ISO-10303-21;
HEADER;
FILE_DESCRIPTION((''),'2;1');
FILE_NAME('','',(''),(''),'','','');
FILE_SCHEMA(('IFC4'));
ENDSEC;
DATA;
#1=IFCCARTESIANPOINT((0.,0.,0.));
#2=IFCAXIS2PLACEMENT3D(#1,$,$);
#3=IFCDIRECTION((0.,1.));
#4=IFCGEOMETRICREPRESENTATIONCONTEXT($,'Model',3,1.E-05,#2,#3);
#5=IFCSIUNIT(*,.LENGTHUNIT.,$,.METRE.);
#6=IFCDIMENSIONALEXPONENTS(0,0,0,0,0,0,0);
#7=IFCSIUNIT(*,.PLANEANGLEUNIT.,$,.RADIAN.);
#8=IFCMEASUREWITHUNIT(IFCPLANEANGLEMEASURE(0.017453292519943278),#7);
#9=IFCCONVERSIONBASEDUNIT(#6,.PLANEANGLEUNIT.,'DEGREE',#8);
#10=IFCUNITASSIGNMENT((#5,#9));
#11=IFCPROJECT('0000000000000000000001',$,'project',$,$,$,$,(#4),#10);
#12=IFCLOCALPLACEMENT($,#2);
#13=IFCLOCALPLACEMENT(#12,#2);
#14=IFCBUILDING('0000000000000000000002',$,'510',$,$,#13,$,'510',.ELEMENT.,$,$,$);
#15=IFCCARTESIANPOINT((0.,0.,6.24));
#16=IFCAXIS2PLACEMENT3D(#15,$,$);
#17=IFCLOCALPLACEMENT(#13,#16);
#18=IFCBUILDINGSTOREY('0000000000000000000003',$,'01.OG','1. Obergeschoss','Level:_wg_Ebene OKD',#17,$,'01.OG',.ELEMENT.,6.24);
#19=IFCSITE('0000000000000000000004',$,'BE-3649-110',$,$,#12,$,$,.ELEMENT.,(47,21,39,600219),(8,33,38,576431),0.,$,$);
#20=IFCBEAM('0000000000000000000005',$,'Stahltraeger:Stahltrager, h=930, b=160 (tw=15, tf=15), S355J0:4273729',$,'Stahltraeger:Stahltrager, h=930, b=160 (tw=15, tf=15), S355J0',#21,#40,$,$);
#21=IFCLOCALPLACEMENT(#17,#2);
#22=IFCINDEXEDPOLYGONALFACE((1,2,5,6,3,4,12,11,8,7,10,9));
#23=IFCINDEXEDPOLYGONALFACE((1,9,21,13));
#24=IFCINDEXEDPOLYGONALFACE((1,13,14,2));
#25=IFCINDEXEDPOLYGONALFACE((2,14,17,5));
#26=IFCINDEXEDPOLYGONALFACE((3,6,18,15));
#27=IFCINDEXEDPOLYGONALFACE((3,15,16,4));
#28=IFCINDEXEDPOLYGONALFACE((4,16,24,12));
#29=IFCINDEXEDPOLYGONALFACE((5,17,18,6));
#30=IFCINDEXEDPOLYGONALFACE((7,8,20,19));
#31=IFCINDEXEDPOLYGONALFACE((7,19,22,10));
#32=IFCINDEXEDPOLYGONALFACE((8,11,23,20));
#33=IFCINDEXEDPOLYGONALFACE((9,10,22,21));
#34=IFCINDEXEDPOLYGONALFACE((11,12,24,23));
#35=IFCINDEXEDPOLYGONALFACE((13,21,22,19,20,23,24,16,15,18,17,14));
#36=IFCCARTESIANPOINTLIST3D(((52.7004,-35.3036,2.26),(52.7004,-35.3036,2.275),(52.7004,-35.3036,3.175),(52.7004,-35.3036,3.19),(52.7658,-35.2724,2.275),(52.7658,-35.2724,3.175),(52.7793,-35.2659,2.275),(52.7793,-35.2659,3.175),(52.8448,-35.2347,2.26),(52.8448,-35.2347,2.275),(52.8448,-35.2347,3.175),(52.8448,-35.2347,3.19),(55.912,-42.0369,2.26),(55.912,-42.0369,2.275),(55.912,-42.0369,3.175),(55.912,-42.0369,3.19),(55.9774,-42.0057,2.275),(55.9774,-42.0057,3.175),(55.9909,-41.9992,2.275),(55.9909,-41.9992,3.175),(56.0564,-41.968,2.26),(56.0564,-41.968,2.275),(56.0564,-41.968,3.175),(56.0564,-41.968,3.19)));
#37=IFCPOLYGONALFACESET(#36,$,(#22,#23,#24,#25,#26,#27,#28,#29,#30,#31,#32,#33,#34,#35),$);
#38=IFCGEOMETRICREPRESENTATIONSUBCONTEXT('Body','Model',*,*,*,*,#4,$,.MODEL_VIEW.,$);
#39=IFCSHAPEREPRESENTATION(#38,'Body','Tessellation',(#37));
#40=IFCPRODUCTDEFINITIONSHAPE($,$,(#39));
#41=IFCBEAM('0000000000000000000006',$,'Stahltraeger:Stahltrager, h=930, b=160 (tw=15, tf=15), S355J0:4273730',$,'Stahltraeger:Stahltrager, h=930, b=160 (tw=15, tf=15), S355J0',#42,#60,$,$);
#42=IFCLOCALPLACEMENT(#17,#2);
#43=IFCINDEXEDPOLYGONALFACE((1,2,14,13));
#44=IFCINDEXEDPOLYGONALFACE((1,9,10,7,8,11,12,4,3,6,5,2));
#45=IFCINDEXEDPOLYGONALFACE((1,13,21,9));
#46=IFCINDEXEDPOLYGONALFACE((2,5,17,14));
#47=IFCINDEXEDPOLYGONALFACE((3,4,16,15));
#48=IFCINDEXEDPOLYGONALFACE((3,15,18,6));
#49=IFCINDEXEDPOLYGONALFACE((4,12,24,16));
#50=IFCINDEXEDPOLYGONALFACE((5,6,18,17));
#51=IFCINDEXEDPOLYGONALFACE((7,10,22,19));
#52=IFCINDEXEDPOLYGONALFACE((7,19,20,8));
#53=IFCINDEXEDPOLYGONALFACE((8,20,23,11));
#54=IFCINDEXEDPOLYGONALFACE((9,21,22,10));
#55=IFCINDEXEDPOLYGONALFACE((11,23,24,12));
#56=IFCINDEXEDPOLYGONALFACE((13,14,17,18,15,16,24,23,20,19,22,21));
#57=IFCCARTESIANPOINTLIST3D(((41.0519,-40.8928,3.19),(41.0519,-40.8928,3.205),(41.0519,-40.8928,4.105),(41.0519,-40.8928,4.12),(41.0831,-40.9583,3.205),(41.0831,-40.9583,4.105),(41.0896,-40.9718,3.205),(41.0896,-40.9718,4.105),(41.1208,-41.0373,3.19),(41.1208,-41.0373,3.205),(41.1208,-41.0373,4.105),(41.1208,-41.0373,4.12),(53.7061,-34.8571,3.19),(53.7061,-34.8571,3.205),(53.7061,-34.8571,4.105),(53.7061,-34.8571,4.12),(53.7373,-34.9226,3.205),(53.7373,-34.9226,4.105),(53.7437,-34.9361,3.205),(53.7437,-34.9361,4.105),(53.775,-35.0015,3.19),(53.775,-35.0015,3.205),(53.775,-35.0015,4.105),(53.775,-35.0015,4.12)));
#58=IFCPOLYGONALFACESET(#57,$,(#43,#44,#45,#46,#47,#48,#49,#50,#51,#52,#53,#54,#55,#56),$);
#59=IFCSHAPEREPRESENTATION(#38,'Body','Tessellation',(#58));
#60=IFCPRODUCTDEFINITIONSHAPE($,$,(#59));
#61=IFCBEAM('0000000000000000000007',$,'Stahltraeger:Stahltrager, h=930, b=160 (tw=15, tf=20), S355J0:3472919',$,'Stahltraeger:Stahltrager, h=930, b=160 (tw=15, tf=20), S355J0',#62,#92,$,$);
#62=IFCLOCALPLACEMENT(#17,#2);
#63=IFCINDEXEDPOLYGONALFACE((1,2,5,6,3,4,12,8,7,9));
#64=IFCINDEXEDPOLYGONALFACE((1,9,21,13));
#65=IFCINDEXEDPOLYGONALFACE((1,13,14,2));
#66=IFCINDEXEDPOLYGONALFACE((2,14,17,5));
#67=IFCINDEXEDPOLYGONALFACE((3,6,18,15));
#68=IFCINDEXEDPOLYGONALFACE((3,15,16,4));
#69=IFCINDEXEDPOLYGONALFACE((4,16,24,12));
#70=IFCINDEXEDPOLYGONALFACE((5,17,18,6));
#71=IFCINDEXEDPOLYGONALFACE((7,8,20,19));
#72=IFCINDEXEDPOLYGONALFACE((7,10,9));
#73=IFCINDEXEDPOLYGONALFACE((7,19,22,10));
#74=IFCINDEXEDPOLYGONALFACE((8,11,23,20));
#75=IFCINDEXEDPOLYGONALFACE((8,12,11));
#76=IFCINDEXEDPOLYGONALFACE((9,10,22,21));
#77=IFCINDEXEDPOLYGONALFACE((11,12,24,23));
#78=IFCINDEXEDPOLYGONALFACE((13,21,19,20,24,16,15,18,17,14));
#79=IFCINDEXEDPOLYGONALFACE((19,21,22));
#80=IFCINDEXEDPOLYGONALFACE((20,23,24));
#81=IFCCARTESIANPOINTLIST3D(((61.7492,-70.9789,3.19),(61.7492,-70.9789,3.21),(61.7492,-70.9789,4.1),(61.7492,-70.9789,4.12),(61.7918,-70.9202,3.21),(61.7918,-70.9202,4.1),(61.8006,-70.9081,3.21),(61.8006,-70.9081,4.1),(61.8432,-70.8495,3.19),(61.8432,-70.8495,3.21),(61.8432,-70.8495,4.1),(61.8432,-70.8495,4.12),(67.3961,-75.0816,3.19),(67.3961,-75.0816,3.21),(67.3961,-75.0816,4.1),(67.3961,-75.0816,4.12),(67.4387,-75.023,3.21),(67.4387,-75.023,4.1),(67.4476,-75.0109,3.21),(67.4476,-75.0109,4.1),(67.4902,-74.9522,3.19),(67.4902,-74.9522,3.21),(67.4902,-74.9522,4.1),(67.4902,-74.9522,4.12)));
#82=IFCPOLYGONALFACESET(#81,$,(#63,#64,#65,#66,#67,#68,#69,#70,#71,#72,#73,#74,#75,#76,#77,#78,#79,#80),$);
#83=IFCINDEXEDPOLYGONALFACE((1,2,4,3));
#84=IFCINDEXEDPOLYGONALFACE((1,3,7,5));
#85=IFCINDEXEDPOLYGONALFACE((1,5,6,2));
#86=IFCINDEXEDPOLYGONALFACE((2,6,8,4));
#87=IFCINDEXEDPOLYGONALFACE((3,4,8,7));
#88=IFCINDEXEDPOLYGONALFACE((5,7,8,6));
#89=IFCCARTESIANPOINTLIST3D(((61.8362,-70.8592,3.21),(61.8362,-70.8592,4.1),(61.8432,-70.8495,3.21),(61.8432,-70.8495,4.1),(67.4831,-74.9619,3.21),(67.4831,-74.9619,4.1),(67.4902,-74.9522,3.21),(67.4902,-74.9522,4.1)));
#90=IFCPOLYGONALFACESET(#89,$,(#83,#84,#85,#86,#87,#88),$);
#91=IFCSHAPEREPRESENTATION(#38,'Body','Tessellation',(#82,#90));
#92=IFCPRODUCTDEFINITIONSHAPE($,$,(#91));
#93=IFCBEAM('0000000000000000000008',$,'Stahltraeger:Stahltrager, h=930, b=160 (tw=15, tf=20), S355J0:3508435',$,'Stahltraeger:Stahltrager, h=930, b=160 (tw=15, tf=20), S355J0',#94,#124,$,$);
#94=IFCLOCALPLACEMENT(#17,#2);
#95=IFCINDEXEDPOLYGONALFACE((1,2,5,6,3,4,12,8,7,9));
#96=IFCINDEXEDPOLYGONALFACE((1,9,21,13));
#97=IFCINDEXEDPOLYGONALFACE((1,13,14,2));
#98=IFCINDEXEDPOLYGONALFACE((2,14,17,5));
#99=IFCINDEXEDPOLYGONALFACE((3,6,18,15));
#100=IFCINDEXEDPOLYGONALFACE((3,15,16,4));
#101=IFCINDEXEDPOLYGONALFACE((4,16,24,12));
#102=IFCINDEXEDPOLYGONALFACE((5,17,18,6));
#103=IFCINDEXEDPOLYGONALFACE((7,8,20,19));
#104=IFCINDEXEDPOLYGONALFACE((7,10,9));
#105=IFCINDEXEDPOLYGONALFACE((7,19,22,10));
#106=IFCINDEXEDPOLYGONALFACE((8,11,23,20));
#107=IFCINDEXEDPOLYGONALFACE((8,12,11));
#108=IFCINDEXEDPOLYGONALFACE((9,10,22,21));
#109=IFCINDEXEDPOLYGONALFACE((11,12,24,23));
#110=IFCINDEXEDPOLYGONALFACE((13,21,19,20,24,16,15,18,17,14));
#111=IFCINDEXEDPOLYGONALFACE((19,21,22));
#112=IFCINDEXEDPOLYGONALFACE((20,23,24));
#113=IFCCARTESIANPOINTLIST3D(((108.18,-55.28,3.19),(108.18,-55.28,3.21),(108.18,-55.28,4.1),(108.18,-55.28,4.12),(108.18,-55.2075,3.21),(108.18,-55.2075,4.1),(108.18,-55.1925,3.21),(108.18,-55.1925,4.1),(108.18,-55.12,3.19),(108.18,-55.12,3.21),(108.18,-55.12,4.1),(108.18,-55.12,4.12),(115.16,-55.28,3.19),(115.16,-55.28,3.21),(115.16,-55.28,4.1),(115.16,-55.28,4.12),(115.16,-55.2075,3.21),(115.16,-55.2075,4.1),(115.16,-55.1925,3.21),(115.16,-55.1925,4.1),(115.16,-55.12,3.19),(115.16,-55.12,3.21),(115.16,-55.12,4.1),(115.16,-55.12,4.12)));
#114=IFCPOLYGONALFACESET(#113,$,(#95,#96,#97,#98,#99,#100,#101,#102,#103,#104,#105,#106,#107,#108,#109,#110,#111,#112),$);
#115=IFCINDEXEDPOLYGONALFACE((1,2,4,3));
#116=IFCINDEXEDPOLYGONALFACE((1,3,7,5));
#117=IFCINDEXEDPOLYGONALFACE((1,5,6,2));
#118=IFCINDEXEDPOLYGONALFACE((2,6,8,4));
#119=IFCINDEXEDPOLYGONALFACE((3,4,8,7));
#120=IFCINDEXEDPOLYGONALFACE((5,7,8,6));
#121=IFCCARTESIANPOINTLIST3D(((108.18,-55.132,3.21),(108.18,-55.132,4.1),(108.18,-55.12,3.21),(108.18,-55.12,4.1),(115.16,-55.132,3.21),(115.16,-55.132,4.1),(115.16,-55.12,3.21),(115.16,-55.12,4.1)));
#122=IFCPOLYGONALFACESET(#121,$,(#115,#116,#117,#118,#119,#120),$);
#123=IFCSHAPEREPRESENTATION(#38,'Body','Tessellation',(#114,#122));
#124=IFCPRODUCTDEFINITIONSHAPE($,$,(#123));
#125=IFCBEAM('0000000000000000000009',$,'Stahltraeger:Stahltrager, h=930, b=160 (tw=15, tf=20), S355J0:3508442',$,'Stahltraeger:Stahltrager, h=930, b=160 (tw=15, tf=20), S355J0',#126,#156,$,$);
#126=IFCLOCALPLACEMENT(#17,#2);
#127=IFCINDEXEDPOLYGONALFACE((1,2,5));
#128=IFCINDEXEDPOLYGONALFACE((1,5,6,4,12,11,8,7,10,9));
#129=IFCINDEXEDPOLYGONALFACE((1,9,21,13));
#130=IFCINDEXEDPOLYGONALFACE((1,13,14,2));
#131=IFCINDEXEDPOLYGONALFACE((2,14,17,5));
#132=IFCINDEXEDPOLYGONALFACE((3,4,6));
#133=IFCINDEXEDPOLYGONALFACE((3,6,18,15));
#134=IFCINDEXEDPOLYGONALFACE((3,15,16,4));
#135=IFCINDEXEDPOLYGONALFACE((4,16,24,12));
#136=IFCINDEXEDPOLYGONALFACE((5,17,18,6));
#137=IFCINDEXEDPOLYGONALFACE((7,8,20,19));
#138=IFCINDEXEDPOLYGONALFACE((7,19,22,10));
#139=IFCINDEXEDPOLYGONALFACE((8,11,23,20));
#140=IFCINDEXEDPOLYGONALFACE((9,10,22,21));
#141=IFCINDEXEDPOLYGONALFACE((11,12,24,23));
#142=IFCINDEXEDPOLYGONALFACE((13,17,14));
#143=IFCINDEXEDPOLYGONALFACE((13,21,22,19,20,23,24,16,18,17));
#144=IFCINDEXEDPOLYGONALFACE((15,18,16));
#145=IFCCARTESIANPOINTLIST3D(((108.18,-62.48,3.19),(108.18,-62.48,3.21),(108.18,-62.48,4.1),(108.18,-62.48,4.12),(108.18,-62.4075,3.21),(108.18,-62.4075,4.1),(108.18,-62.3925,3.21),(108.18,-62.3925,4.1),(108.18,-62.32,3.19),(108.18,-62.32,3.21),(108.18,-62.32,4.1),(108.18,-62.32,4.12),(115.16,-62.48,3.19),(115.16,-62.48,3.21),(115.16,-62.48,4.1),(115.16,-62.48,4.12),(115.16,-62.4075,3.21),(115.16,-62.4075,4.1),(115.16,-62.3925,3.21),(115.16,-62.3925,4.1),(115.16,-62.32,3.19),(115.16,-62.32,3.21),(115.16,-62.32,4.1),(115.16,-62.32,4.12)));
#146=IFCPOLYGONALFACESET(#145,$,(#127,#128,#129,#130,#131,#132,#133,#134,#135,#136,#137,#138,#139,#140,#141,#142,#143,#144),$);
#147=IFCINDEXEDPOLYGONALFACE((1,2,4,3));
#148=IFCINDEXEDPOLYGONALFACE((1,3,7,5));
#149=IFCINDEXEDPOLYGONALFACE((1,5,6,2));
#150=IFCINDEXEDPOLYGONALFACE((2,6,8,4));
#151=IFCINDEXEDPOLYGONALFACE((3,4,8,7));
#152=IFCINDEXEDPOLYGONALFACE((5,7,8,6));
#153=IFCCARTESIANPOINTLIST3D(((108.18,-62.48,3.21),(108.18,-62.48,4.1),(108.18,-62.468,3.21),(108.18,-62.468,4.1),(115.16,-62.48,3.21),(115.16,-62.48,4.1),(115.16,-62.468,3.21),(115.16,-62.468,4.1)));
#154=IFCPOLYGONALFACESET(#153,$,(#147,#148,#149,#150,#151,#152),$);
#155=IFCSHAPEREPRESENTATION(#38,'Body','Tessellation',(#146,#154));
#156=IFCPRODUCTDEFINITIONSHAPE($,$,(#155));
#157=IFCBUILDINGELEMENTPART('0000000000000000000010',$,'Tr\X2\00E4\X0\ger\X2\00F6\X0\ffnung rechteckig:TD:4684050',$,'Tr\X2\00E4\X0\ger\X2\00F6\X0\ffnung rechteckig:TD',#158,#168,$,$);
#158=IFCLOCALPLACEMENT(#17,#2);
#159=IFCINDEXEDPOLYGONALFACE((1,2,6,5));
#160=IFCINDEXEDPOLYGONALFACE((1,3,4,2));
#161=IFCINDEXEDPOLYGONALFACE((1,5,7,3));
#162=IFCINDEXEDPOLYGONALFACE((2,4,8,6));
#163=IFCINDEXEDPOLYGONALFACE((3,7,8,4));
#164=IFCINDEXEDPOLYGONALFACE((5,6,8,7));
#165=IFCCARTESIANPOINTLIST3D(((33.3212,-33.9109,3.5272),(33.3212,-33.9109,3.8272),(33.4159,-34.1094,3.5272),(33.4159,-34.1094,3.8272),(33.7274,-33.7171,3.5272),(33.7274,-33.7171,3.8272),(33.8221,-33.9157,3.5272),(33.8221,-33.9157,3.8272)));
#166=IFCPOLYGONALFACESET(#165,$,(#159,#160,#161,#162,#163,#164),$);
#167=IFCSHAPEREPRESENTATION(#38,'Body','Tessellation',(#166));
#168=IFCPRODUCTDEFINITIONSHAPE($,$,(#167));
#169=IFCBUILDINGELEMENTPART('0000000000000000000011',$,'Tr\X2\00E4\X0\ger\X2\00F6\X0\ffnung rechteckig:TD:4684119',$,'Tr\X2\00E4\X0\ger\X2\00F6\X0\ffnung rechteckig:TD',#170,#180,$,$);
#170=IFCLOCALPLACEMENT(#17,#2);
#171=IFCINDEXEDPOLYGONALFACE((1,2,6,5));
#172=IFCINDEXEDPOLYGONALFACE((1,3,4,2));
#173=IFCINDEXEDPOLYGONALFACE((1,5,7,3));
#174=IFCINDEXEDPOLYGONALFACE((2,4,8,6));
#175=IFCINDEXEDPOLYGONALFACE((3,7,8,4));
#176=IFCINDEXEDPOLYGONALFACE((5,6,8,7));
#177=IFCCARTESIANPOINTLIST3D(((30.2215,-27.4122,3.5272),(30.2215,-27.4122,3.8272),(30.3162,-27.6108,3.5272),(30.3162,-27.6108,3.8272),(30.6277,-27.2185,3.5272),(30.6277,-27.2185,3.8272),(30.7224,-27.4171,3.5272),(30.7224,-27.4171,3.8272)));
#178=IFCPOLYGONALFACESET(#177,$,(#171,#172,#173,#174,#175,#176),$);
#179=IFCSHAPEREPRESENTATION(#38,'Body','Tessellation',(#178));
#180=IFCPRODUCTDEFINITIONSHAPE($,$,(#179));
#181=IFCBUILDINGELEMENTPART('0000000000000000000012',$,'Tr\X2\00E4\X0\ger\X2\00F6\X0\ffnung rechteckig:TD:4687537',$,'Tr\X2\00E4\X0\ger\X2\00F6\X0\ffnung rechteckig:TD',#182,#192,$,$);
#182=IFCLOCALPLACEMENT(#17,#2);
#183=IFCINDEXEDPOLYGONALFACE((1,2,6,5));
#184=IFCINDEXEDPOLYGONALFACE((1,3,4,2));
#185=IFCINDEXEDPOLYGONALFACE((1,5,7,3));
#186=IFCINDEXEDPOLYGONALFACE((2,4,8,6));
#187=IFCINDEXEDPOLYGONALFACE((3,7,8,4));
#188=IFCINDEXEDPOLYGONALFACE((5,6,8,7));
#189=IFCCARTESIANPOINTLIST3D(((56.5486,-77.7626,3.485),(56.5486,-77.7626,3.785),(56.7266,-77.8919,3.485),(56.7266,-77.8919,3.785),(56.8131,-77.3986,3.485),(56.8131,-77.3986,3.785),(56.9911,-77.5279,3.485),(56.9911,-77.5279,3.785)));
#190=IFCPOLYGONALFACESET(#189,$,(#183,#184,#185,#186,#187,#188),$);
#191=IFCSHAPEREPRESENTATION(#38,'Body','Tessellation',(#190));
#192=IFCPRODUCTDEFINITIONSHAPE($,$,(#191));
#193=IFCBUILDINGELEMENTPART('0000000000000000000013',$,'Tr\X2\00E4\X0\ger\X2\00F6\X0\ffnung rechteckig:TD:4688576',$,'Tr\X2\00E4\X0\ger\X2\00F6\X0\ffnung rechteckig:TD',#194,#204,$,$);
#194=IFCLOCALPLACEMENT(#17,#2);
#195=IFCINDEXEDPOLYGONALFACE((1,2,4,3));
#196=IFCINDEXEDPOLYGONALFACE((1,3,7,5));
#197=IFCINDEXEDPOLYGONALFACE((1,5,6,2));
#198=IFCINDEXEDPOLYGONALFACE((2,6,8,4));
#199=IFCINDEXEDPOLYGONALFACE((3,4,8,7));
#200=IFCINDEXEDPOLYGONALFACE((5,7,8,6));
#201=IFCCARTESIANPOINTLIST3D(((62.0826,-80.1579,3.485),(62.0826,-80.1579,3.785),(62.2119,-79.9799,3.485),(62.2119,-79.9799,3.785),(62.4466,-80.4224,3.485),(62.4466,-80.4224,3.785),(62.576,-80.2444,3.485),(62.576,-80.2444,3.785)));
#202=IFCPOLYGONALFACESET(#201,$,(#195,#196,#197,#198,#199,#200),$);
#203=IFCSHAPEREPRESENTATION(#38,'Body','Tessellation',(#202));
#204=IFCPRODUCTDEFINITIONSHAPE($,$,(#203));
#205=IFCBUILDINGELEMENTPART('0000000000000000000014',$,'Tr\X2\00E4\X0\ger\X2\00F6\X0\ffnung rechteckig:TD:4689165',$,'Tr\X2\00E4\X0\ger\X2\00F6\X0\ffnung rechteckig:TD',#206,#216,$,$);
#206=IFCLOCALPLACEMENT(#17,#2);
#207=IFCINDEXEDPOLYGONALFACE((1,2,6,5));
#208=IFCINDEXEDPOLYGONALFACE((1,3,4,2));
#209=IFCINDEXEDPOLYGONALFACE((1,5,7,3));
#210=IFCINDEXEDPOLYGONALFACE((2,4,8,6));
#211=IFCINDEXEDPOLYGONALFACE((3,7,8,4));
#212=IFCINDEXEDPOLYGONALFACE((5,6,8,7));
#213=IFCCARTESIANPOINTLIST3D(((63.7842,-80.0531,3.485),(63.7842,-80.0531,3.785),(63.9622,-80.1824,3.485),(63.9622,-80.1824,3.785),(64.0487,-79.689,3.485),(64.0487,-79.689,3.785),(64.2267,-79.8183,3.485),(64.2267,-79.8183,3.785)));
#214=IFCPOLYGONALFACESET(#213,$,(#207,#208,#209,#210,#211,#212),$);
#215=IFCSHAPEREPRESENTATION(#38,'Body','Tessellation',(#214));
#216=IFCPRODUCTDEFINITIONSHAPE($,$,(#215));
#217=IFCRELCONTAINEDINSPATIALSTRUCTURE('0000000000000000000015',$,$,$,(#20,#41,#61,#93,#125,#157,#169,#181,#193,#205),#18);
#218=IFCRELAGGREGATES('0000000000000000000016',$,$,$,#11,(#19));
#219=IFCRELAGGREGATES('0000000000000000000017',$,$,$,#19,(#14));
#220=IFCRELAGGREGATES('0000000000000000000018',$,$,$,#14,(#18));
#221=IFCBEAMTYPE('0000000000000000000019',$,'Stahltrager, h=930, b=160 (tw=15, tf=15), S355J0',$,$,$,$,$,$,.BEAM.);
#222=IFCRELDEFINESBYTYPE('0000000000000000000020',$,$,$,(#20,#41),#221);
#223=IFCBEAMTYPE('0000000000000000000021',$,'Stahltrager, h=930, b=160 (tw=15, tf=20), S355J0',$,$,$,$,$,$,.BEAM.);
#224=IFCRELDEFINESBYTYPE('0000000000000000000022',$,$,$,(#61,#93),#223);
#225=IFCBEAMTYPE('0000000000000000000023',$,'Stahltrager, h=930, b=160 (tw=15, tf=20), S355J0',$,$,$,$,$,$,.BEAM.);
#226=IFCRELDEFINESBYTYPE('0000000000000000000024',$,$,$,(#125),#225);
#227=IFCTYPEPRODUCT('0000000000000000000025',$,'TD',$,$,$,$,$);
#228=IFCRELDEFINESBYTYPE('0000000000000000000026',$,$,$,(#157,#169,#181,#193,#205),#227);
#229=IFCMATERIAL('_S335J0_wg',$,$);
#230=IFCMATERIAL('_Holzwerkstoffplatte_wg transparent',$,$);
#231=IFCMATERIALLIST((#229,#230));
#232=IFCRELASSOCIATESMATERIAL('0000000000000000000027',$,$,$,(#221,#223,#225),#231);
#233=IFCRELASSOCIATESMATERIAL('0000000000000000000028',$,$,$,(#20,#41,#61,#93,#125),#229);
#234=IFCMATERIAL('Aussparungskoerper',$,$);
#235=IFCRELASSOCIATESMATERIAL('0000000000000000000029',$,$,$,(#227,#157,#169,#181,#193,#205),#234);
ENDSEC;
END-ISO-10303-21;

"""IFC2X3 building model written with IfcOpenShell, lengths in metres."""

from ifc_helpers import new_model, entity, si_unit, converted_unit, direction, frame, frame_2d, origin, origin_2d_with_axis, place, context, subcontext, project, spatial, rectangle, i_section, extrude, source, transform, mapped, material, material_list, type_object, type_shapes, element, save


model = new_model("IFC2X3")

# Units and contexts
model_context = context("Model", 3, precision=1e-05, world=origin(), true_north=direction((0.0, 1.0)))
body_context = subcontext(model_context, "Body", "Model", "MODEL_VIEW")
ifc_project = project(units=[si_unit("LENGTHUNIT", "METRE"), converted_unit("PLANEANGLEUNIT", "DEGREE", entity("IfcPlaneAngleMeasure", 0.017453292519943278), si_unit("PLANEANGLEUNIT", "RADIAN"), dimensions=[0, 0, 0, 0, 0, 0, 0])], contexts=[model_context])

# Site, building, storey
site_placement = place(None, origin())
site = spatial("IfcSite", under=ifc_project, at=site_placement, Name="BE-3649-110", CompositionType="ELEMENT", RefLatitude=(47, 21, 39, 600219), RefLongitude=(8, 33, 38, 576431), RefElevation=0.0)
building_placement = place(site_placement, origin())
building = spatial("IfcBuilding", under=site, at=building_placement, Name="510", LongName="510", CompositionType="ELEMENT")
storey_placement = place(building_placement, frame((0.0, 0.0, 6.24)))
storey = spatial("IfcBuildingStorey", under=building, at=storey_placement, Name="01.OG", Description="1. Obergeschoss", ObjectType="Level:_wg_Ebene OKD", LongName="01.OG", CompositionType="ELEMENT", Elevation=6.24)

# Beams
ifc_material_1 = material(Name="_S335J0_wg")
ifc_material_2 = material(Name="_Holzwerkstoffplatte_wg transparent")
ifc_material_list = material_list([ifc_material_1, ifc_material_2])
beam_type_1 = type_object("IfcBeamType", Name="Stahltrager, h=930, b=160 (tw=15, tf=15), S355J0", PredefinedType="BEAM", material=ifc_material_list)
beam_1_placement = place(storey_placement, frame((52.7726, -35.2691, 3.19), z_axis=(0.0, 0.0, 1.0), x_axis=(0.430511, -0.902585, 0.0)))
element("IfcBeam", 1, at=beam_1_placement, inside=storey, type_object=beam_type_1, material=ifc_material_1, Name="Stahltraeger:Stahltrager, h=930, b=160 (tw=15, tf=15), S355J0:4273729", ObjectType="Stahltraeger:Stahltrager, h=930, b=160 (tw=15, tf=15), S355J0", context=body_context, shape_type="SweptSolid", body=[
    extrude(i_section(OverallWidth=0.16, OverallDepth=0.93, WebThickness=0.015, FlangeThickness=0.015, at=frame_2d((0.0, 0.0), x_axis=(0.0, 1.0))), frame((0.0, 0.0, -0.465), z_axis=(1.0, 0.0, 0.0), x_axis=(0.0, 0.0, -1.0)), (0.0, 0.0, 1.0), 7.46),
])
beam_2_placement = place(storey_placement, frame((41.0863, -40.9651, 4.12), z_axis=(0.0, 0.0, 1.0), x_axis=(0.902585, 0.430511, 0.0)))
element("IfcBeam", 2, at=beam_2_placement, inside=storey, type_object=beam_type_1, material=ifc_material_1, Name="Stahltraeger:Stahltrager, h=930, b=160 (tw=15, tf=15), S355J0:4273730", ObjectType="Stahltraeger:Stahltrager, h=930, b=160 (tw=15, tf=15), S355J0", context=body_context, shape_type="SweptSolid", body=[
    extrude(i_section(OverallWidth=0.16, OverallDepth=0.93, WebThickness=0.015, FlangeThickness=0.015, at=frame_2d((0.0, 0.0), x_axis=(0.0, 1.0))), frame((0.0, 0.0, -0.465), z_axis=(1.0, 0.0, 0.0), x_axis=(0.0, 0.0, -1.0)), (0.0, 0.0, 1.0), 14.0199),
])
beam_type_2 = type_object("IfcBeamType", Name="Stahltrager, h=930, b=160 (tw=15, tf=20), S355J0", PredefinedType="BEAM", material=ifc_material_list)
shared_shape_1 = source(origin(), body_context, "Body", "SweptSolid", [
    extrude(i_section(OverallWidth=0.16, OverallDepth=0.93, WebThickness=0.015, FlangeThickness=0.02, at=frame_2d((0.0, 0.0), x_axis=(0.0, 1.0))), frame((-3.49, 0.0, 0.0), z_axis=(1.0, 0.0, 0.0), x_axis=(0.0, 0.0, -1.0)), (0.0, 0.0, 1.0), 6.98),
    extrude(rectangle(XDim=0.89, YDim=0.012, at=origin_2d_with_axis()), frame((-3.49, 0.074, 0.0), z_axis=(1.0, 0.0, 0.0), x_axis=(0.0, 0.0, -1.0)), (0.0, 0.0, 1.0), 6.98),
])
type_shapes(beam_type_2, [shared_shape_1])
beam_3_placement = place(storey_placement, frame((64.6197, -72.9655, 3.655), z_axis=(0.0, 0.0, 1.0), x_axis=(0.809017, -0.587785, 0.0)))
element("IfcBeam", 3, at=beam_3_placement, inside=storey, type_object=beam_type_2, material=ifc_material_1, Name="Stahltraeger:Stahltrager, h=930, b=160 (tw=15, tf=20), S355J0:3472919", ObjectType="Stahltraeger:Stahltrager, h=930, b=160 (tw=15, tf=20), S355J0", context=body_context, shape_type="MappedRepresentation", body=[
    mapped(shared_shape_1, transform((0.0, 0.0, 0.0), scale=1.0)),
])
beam_4_placement = place(storey_placement, frame((111.67, -55.2, 3.655)))
element("IfcBeam", 4, at=beam_4_placement, inside=storey, type_object=beam_type_2, material=ifc_material_1, Name="Stahltraeger:Stahltrager, h=930, b=160 (tw=15, tf=20), S355J0:3508435", ObjectType="Stahltraeger:Stahltrager, h=930, b=160 (tw=15, tf=20), S355J0", context=body_context, shape_type="MappedRepresentation", body=[
    mapped(shared_shape_1, transform((0.0, 0.0, 0.0), scale=1.0)),
])
beam_type_3 = type_object("IfcBeamType", Name="Stahltrager, h=930, b=160 (tw=15, tf=20), S355J0", PredefinedType="BEAM", material=ifc_material_list)
shared_shape_2 = source(origin(), body_context, "Body", "SweptSolid", [
    extrude(i_section(OverallWidth=0.16, OverallDepth=0.93, WebThickness=0.015, FlangeThickness=0.02, at=frame_2d((0.0, 0.0), x_axis=(0.0, 1.0))), frame((-3.49, 0.0, 0.0), z_axis=(1.0, 0.0, 0.0), x_axis=(0.0, 0.0, -1.0)), (0.0, 0.0, 1.0), 6.98),
    extrude(rectangle(XDim=0.89, YDim=0.012, at=frame_2d((0.0, 0.0), x_axis=(1.0, 0.0))), frame((-3.49, -0.074, 0.0), z_axis=(1.0, 0.0, 0.0), x_axis=(0.0, 0.0, -1.0)), (0.0, 0.0, 1.0), 6.98),
])
type_shapes(beam_type_3, [shared_shape_2])
beam_5_placement = place(storey_placement, frame((111.67, -62.4, 3.655)))
element("IfcBeam", 5, at=beam_5_placement, inside=storey, type_object=beam_type_3, material=ifc_material_1, Name="Stahltraeger:Stahltrager, h=930, b=160 (tw=15, tf=20), S355J0:3508442", ObjectType="Stahltraeger:Stahltrager, h=930, b=160 (tw=15, tf=20), S355J0", context=body_context, shape_type="MappedRepresentation", body=[
    mapped(shared_shape_2, transform((0.0, 0.0, 0.0), scale=1.0)),
])

# Building element parts
ifc_material_3 = material(Name="Aussparungskoerper")
type_product_1 = type_object("IfcTypeProduct", Name="TD", material=ifc_material_3)
shared_shape_3 = source(origin(), body_context, "Body", "SweptSolid", [
    extrude(rectangle(XDim=0.45, YDim=0.3, at=origin_2d_with_axis()), frame((0.0, 0.0, -0.22), z_axis=(0.0, 0.0, 1.0), x_axis=(-1.0, 0.0, 0.0)), (0.0, 0.0, 1.0), 0.22),
])
type_shapes(type_product_1, [shared_shape_3])
for number, where, z_axis, x_axis, name in (
    (6, (33.619, -34.0126, 3.6772), (0.430511, -0.902585, 0.0), (-0.902585, -0.430511, 0.0), "Trägeröffnung rechteckig:TD:4684050"),
    (7, (30.5193, -27.5139, 3.6772), (0.430511, -0.902585, 0.0), (-0.902585, -0.430511, 0.0), "Trägeröffnung rechteckig:TD:4684119"),
    (8, (56.8588, -77.7099, 3.635), (0.809017, -0.587785, 0.0), (-0.587785, -0.809017, 0.0), "Trägeröffnung rechteckig:TD:4687537"),
    (9, (62.2646, -80.2901, 3.635), (-0.587785, -0.809017, 0.0), (0.809017, -0.587785, 0.0), "Trägeröffnung rechteckig:TD:4688576"),
    (10, (64.0944, -80.0003, 3.635), (0.809017, -0.587785, 0.0), (-0.587785, -0.809017, 0.0), "Trägeröffnung rechteckig:TD:4689165"),
):
    element("IfcBuildingElementPart", number, at=place(storey_placement, frame(where, z_axis=z_axis, x_axis=x_axis)), inside=storey, type_object=type_product_1, material=ifc_material_3, Name=name, ObjectType="Trägeröffnung rechteckig:TD", context=body_context, shape_type="MappedRepresentation", body=[
        mapped(shared_shape_3, transform((0.0, 0.0, 0.0), scale=1.0)),
    ])

save(model, "model.ifc")
